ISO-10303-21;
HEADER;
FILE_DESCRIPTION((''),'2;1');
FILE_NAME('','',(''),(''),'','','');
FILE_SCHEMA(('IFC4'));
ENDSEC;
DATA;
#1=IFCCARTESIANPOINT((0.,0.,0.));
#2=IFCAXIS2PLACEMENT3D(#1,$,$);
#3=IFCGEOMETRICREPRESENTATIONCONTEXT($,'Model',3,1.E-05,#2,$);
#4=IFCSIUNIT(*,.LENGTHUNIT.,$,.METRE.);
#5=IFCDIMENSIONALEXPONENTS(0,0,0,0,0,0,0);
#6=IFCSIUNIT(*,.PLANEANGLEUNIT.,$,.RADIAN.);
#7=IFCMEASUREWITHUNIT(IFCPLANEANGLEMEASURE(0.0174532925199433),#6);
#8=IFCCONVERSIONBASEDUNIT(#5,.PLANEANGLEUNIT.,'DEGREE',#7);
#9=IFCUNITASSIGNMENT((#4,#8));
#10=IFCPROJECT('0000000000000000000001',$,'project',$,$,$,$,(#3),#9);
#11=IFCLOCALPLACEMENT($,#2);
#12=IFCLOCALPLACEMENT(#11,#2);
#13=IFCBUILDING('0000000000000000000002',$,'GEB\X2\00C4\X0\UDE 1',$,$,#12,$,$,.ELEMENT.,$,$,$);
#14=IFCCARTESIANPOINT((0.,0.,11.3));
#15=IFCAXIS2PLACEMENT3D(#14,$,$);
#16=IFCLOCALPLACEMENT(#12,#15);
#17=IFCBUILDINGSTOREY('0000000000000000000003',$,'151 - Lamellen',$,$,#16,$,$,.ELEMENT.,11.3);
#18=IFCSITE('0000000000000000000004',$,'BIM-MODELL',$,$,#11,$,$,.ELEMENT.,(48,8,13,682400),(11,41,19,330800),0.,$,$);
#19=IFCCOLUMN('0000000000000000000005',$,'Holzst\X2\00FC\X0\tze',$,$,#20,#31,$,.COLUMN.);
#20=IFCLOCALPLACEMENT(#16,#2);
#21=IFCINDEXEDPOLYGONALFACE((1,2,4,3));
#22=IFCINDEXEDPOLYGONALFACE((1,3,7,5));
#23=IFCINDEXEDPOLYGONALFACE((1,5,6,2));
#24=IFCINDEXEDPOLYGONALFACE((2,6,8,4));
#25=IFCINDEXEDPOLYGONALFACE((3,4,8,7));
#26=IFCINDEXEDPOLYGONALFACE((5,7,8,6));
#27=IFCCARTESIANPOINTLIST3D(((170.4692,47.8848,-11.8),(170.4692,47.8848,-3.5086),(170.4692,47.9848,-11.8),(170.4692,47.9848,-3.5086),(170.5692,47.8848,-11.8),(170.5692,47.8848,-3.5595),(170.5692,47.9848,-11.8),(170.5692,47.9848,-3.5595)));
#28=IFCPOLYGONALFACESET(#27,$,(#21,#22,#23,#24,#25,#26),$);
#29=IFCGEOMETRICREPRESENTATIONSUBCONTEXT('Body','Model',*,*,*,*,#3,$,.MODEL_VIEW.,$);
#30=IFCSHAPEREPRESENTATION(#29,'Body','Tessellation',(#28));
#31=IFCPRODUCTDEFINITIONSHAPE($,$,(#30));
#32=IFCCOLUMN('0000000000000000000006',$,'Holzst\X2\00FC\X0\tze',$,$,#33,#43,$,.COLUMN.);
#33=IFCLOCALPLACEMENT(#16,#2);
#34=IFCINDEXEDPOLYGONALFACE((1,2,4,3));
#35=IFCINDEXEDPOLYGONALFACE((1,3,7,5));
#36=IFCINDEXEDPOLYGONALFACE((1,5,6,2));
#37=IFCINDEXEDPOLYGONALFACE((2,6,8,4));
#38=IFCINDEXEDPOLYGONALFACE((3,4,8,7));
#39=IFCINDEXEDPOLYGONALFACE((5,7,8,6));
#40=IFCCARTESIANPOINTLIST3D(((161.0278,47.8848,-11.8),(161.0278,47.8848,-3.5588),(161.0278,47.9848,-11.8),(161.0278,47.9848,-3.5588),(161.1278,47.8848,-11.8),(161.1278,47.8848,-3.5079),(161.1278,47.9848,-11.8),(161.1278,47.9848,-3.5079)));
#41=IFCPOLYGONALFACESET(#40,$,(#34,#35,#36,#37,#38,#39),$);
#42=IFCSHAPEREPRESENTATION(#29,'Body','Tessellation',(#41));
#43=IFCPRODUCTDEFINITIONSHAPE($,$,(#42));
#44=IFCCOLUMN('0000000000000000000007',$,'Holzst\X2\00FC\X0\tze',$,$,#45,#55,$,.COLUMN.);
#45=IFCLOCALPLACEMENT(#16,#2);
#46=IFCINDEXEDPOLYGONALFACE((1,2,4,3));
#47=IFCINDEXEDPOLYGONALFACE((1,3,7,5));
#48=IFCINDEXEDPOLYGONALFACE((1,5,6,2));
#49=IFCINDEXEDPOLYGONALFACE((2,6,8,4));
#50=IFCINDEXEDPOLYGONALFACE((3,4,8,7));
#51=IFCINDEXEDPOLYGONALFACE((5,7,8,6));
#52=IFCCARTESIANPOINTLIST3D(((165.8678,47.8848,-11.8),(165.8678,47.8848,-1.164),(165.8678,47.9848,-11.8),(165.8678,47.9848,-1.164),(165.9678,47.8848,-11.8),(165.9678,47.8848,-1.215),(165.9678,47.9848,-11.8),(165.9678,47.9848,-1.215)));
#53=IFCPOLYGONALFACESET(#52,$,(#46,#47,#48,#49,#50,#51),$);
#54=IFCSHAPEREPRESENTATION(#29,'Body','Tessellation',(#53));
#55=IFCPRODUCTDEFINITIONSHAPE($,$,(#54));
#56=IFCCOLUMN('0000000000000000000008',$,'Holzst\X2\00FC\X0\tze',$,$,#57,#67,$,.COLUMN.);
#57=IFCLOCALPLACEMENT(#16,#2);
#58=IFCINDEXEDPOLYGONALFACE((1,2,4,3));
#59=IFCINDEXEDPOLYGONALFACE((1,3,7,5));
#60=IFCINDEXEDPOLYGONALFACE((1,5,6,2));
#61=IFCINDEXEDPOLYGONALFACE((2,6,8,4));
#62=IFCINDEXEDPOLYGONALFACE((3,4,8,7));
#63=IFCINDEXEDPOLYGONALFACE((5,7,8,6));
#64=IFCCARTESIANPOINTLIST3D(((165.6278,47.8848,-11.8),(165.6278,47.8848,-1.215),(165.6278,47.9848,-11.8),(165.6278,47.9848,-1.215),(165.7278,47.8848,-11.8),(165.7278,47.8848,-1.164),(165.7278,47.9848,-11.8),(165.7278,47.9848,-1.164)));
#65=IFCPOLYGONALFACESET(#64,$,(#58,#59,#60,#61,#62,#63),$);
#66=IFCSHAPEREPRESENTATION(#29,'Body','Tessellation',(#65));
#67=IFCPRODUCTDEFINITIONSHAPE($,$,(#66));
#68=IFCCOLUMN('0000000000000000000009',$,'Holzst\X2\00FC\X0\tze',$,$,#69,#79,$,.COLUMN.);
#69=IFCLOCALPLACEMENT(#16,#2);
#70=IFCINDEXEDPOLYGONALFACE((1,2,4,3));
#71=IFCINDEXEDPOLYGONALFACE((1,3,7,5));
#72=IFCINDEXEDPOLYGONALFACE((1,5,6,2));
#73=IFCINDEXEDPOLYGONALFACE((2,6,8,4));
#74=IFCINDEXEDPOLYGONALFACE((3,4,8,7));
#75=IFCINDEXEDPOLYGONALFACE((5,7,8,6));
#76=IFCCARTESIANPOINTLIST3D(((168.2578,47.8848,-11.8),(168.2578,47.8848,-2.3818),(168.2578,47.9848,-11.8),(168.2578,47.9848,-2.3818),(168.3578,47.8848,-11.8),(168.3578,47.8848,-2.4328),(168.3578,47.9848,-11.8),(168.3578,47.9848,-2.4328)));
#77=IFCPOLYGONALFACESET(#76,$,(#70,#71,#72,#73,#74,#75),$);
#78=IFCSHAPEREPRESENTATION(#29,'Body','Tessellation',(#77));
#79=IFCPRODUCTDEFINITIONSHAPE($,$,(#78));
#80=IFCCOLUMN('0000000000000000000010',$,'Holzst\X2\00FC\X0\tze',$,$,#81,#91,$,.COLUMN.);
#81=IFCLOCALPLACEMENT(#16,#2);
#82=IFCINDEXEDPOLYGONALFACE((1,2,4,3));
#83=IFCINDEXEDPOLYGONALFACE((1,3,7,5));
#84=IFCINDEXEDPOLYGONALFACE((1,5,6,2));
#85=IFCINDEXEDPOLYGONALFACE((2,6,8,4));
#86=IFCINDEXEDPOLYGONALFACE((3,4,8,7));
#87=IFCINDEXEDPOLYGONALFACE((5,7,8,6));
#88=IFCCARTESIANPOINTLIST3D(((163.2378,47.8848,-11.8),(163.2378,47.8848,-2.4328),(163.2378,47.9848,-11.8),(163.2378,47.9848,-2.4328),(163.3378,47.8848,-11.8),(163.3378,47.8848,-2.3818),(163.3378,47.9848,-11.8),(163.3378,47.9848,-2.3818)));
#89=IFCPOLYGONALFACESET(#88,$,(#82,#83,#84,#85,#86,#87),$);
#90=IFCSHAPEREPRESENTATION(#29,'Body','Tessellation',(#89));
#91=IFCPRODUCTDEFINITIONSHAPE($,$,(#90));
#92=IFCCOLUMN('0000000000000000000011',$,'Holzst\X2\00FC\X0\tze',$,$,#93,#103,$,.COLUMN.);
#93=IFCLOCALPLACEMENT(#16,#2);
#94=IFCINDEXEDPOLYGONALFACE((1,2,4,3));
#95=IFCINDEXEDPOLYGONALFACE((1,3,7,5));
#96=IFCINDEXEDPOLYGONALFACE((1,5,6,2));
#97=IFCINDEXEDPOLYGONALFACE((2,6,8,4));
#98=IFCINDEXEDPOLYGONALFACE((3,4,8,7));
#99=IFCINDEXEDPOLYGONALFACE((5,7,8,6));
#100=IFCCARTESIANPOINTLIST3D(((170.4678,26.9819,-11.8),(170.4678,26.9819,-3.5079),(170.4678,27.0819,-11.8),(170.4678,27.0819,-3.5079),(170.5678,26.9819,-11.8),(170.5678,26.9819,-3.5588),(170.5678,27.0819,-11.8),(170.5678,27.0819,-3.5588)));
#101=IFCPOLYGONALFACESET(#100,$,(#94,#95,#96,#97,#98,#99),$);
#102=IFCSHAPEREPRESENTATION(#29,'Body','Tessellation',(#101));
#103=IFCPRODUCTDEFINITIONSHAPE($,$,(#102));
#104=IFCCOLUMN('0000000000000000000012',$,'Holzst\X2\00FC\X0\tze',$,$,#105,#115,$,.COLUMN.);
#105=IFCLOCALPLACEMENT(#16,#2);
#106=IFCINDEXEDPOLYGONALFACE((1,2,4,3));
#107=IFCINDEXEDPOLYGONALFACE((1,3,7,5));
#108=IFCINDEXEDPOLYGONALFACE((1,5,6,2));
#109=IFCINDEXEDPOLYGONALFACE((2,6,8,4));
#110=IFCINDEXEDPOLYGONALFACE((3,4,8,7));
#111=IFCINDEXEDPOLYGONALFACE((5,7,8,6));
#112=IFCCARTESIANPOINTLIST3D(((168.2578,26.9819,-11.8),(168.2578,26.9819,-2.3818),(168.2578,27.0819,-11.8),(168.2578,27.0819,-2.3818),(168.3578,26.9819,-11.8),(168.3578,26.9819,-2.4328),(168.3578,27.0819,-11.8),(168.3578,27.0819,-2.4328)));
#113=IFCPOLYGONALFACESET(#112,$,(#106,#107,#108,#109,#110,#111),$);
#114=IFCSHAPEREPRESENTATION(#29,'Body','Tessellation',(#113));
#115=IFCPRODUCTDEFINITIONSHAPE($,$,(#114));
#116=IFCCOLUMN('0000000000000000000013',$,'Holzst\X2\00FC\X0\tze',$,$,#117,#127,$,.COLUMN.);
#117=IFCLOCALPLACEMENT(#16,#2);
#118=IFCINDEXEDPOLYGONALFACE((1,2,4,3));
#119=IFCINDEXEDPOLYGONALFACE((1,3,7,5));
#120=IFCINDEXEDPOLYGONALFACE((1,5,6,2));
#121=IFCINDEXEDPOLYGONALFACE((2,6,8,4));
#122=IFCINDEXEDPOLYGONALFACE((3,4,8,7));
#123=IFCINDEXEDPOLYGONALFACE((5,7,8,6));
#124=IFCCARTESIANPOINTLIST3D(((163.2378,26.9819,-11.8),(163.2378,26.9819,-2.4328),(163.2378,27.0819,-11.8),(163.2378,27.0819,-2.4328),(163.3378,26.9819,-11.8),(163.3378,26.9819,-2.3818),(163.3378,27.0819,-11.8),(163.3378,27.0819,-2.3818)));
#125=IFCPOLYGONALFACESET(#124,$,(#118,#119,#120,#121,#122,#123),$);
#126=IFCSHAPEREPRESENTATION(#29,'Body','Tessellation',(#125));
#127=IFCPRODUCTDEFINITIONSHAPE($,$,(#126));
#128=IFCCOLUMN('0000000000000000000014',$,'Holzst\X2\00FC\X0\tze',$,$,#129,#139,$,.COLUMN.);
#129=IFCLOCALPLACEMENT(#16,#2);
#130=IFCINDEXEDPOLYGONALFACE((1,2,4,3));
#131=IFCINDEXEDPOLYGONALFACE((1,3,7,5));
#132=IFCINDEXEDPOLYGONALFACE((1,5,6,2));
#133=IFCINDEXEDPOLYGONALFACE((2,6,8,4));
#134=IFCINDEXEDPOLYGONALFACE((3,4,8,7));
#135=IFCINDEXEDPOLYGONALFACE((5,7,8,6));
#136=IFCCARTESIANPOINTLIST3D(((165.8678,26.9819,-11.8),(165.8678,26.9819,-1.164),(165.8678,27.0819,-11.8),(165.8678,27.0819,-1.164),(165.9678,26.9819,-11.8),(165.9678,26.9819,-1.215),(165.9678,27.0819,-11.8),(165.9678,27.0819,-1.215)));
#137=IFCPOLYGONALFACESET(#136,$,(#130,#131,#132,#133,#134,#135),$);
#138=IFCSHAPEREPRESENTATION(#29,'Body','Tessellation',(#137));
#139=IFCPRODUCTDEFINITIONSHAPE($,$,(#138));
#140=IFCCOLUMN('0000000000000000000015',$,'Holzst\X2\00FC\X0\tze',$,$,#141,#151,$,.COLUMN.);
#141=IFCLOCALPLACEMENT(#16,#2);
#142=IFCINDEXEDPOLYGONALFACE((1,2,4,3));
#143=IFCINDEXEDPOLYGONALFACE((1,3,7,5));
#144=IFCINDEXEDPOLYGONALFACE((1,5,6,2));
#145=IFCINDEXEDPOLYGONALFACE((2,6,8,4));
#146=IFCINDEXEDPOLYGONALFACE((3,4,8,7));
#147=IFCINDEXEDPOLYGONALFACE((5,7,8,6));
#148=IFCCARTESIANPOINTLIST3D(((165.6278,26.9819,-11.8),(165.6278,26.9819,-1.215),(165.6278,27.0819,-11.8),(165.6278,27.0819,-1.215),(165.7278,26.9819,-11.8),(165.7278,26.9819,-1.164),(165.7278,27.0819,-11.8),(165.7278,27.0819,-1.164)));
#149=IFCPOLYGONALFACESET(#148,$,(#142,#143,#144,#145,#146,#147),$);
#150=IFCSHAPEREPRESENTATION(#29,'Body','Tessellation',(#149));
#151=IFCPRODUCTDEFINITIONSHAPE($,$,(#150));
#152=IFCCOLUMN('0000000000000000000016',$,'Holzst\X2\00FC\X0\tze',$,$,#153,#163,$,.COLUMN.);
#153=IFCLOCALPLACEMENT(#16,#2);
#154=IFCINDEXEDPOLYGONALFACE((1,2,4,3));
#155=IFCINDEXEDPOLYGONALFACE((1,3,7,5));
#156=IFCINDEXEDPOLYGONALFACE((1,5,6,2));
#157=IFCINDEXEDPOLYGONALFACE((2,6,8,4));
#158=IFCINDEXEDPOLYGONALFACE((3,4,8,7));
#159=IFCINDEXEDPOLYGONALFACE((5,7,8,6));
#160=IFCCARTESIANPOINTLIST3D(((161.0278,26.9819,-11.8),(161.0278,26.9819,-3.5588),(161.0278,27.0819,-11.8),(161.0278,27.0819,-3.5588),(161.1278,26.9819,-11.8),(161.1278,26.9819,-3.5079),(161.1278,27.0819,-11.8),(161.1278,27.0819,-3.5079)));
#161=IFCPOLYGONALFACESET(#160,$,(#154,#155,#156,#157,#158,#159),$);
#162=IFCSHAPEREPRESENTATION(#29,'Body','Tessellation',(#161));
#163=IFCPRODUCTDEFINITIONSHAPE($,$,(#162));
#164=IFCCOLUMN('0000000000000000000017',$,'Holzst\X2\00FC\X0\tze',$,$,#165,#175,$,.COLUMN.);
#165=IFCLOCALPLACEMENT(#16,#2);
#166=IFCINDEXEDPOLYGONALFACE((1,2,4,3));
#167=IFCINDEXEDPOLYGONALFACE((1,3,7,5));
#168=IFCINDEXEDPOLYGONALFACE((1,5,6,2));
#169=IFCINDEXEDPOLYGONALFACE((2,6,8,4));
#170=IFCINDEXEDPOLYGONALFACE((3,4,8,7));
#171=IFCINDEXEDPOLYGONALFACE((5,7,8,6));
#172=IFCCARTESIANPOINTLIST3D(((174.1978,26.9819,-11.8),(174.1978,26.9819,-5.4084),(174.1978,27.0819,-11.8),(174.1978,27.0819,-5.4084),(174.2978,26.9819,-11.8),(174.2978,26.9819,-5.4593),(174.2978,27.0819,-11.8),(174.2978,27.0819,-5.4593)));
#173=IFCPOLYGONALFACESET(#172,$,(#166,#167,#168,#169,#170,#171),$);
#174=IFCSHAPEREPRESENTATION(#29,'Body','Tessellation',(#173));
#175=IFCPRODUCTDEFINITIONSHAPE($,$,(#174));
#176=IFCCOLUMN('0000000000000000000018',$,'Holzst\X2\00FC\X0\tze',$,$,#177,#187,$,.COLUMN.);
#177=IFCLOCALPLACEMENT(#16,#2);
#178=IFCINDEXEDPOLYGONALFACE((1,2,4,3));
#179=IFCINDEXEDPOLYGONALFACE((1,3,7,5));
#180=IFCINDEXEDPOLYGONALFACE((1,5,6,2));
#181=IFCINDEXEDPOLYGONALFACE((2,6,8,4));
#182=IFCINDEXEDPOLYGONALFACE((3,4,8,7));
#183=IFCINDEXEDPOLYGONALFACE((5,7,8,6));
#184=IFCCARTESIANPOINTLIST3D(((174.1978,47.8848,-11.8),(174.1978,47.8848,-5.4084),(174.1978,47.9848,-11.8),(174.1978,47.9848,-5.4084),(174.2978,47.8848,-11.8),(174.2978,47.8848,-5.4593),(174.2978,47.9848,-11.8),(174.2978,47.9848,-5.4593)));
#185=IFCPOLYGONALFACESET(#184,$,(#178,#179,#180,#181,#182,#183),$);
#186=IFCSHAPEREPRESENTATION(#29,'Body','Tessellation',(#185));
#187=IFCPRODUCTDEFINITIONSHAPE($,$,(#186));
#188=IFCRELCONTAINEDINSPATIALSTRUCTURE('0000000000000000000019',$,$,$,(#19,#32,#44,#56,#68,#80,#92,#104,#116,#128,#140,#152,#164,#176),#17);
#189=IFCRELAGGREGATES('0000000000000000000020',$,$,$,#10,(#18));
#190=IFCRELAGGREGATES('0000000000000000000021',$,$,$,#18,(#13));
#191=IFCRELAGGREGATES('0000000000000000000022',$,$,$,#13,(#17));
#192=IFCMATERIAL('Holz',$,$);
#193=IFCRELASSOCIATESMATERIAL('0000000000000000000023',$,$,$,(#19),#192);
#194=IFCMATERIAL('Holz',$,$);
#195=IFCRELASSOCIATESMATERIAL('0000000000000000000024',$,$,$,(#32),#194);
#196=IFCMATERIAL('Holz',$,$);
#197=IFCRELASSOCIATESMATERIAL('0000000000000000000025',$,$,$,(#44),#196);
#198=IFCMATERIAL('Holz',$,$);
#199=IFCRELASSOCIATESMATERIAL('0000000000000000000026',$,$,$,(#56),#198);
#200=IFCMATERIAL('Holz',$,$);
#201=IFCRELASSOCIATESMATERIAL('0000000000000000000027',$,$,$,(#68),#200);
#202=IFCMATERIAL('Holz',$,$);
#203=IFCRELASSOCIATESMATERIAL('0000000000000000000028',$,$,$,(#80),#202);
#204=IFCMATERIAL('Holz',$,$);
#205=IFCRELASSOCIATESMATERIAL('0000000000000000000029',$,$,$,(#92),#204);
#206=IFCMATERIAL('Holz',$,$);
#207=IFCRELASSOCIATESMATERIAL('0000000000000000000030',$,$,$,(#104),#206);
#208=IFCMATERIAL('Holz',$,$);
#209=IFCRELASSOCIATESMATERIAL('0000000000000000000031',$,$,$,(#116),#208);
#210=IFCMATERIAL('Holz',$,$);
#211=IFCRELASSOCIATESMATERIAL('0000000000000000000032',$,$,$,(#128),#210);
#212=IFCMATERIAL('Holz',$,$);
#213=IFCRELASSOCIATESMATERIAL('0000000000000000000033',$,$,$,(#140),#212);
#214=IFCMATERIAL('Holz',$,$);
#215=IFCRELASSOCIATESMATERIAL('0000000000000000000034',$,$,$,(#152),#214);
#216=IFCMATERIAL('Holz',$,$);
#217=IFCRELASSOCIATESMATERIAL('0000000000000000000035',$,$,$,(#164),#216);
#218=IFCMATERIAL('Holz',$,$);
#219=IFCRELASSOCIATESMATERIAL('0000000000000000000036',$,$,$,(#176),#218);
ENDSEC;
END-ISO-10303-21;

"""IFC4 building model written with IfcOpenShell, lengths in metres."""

from ifc_helpers import new_model, entity, si_unit, converted_unit, frame, frame_2d, origin, origin_with_axes, place, context, subcontext, project, spatial, rectangle, extrude, clip, halfspace, material, element, save


model = new_model("IFC4")

# Units and contexts
model_context = context("Model", 3, precision=1e-05, world=origin())
body_context = subcontext(model_context, "Body", "Model", "MODEL_VIEW")
ifc_project = project(units=[si_unit("LENGTHUNIT", "METRE"), converted_unit("PLANEANGLEUNIT", "DEGREE", entity("IfcPlaneAngleMeasure", 0.0174532925199433), si_unit("PLANEANGLEUNIT", "RADIAN"), dimensions=[0, 0, 0, 0, 0, 0, 0])], contexts=[model_context])

# Site, building, storey
site_placement = place(None, origin())
site = spatial("IfcSite", under=ifc_project, at=site_placement, Name="BIM-MODELL", CompositionType="ELEMENT", RefLatitude=(48, 8, 13, 682400), RefLongitude=(11, 41, 19, 330800), RefElevation=0.0)
building_placement = place(site_placement, origin())
building = spatial("IfcBuilding", under=site, at=building_placement, Name="GEBÄUDE 1", CompositionType="ELEMENT")
storey_placement = place(building_placement, frame((0.0, 0.0, 11.3)))
storey = spatial("IfcBuildingStorey", under=building, at=storey_placement, Name="151 - Lamellen", CompositionType="ELEMENT", Elevation=11.3)

# Columns
ifc_material_1 = material(Name="Holz")
column_1_placement = place(storey_placement, frame((170.5692, 47.8848, -11.8)))
element("IfcColumn", 1, at=column_1_placement, inside=storey, material=ifc_material_1, Name="Holzstütze", PredefinedType="COLUMN", context=body_context, shape_type="Clipping", body=[
    clip(extrude(rectangle(XDim=0.1, YDim=0.1, at=frame_2d((-0.05, 0.05), x_axis=(0.0, 1.0))), origin_with_axes(), (0.0, 0.0, 1.0), 8.2914), halfspace(frame((-0.05, 0.05, 8.2659), z_axis=(-0.45399, 0.0, -0.891007), x_axis=(0.0, 1.0, 0.0)), True)),
])
ifc_material_2 = material(Name="Holz")
column_2_placement = place(storey_placement, frame((161.1278, 47.8848, -11.8)))
element("IfcColumn", 2, at=column_2_placement, inside=storey, material=ifc_material_2, Name="Holzstütze", PredefinedType="COLUMN", context=body_context, shape_type="Clipping", body=[
    clip(extrude(rectangle(XDim=0.1, YDim=0.1, at=frame_2d((-0.05, 0.05), x_axis=(0.0, 1.0))), origin_with_axes(), (0.0, 0.0, 1.0), 8.2921), halfspace(frame((-0.05, 0.05, 8.2667), z_axis=(0.45399, 0.0, -0.891007), x_axis=(0.0, 1.0, 0.0)), True)),
])
ifc_material_3 = material(Name="Holz")
column_3_placement = place(storey_placement, frame((165.9678, 47.8848, -11.8)))
element("IfcColumn", 3, at=column_3_placement, inside=storey, material=ifc_material_3, Name="Holzstütze", PredefinedType="COLUMN", context=body_context, shape_type="Clipping", body=[
    clip(extrude(rectangle(XDim=0.1, YDim=0.1, at=frame_2d((-0.05, 0.05), x_axis=(0.0, 1.0))), origin_with_axes(), (0.0, 0.0, 1.0), 10.636), halfspace(frame((-0.05, 0.05, 10.6105), z_axis=(-0.45399, 0.0, -0.891007), x_axis=(0.0, 1.0, 0.0)), True)),
])
ifc_material_4 = material(Name="Holz")
column_4_placement = place(storey_placement, frame((165.7278, 47.8848, -11.8)))
element("IfcColumn", 4, at=column_4_placement, inside=storey, material=ifc_material_4, Name="Holzstütze", PredefinedType="COLUMN", context=body_context, shape_type="Clipping", body=[
    clip(extrude(rectangle(XDim=0.1, YDim=0.1, at=frame_2d((-0.05, 0.05), x_axis=(0.0, 1.0))), origin_with_axes(), (0.0, 0.0, 1.0), 10.636), halfspace(frame((-0.05, 0.05, 10.6105), z_axis=(0.45399, 0.0, -0.891007), x_axis=(0.0, 1.0, 0.0)), True)),
])
ifc_material_5 = material(Name="Holz")
column_5_placement = place(storey_placement, frame((168.3578, 47.8848, -11.8)))
element("IfcColumn", 5, at=column_5_placement, inside=storey, material=ifc_material_5, Name="Holzstütze", PredefinedType="COLUMN", context=body_context, shape_type="Clipping", body=[
    clip(extrude(rectangle(XDim=0.1, YDim=0.1, at=frame_2d((-0.05, 0.05), x_axis=(0.0, 1.0))), origin_with_axes(), (0.0, 0.0, 1.0), 9.4182), halfspace(frame((-0.05, 0.05, 9.3927), z_axis=(-0.45399, 0.0, -0.891007), x_axis=(0.0, 1.0, 0.0)), True)),
])
ifc_material_6 = material(Name="Holz")
column_6_placement = place(storey_placement, frame((163.3378, 47.8848, -11.8)))
element("IfcColumn", 6, at=column_6_placement, inside=storey, material=ifc_material_6, Name="Holzstütze", PredefinedType="COLUMN", context=body_context, shape_type="Clipping", body=[
    clip(extrude(rectangle(XDim=0.1, YDim=0.1, at=frame_2d((-0.05, 0.05), x_axis=(0.0, 1.0))), origin_with_axes(), (0.0, 0.0, 1.0), 9.4182), halfspace(frame((-0.05, 0.05, 9.3927), z_axis=(0.45399, 0.0, -0.891007), x_axis=(0.0, 1.0, 0.0)), True)),
])
ifc_material_7 = material(Name="Holz")
column_7_placement = place(storey_placement, frame((170.5678, 26.9819, -11.8)))
element("IfcColumn", 7, at=column_7_placement, inside=storey, material=ifc_material_7, Name="Holzstütze", PredefinedType="COLUMN", context=body_context, shape_type="Clipping", body=[
    clip(extrude(rectangle(XDim=0.1, YDim=0.1, at=frame_2d((-0.05, 0.05), x_axis=(0.0, 1.0))), origin_with_axes(), (0.0, 0.0, 1.0), 8.2921), halfspace(frame((-0.05, 0.05, 8.2667), z_axis=(-0.45399, 0.0, -0.891007), x_axis=(0.0, -1.0, 0.0)), True)),
])
ifc_material_8 = material(Name="Holz")
column_8_placement = place(storey_placement, frame((168.3578, 26.9819, -11.8)))
element("IfcColumn", 8, at=column_8_placement, inside=storey, material=ifc_material_8, Name="Holzstütze", PredefinedType="COLUMN", context=body_context, shape_type="Clipping", body=[
    clip(extrude(rectangle(XDim=0.1, YDim=0.1, at=frame_2d((-0.05, 0.05), x_axis=(0.0, 1.0))), origin_with_axes(), (0.0, 0.0, 1.0), 9.4182), halfspace(frame((-0.05, 0.05, 9.3927), z_axis=(-0.45399, 0.0, -0.891007), x_axis=(0.0, -1.0, 0.0)), True)),
])
ifc_material_9 = material(Name="Holz")
column_9_placement = place(storey_placement, frame((163.3378, 26.9819, -11.8)))
element("IfcColumn", 9, at=column_9_placement, inside=storey, material=ifc_material_9, Name="Holzstütze", PredefinedType="COLUMN", context=body_context, shape_type="Clipping", body=[
    clip(extrude(rectangle(XDim=0.1, YDim=0.1, at=frame_2d((-0.05, 0.05), x_axis=(0.0, 1.0))), origin_with_axes(), (0.0, 0.0, 1.0), 9.4182), halfspace(frame((-0.05, 0.05, 9.3927), z_axis=(0.45399, 0.0, -0.891007), x_axis=(0.0, -1.0, 0.0)), True)),
])
ifc_material_10 = material(Name="Holz")
column_10_placement = place(storey_placement, frame((165.9678, 26.9819, -11.8)))
element("IfcColumn", 10, at=column_10_placement, inside=storey, material=ifc_material_10, Name="Holzstütze", PredefinedType="COLUMN", context=body_context, shape_type="Clipping", body=[
    clip(extrude(rectangle(XDim=0.1, YDim=0.1, at=frame_2d((-0.05, 0.05), x_axis=(0.0, 1.0))), origin_with_axes(), (0.0, 0.0, 1.0), 10.636), halfspace(frame((-0.05, 0.05, 10.6105), z_axis=(-0.45399, 0.0, -0.891007), x_axis=(0.0, -1.0, 0.0)), True)),
])
ifc_material_11 = material(Name="Holz")
column_11_placement = place(storey_placement, frame((165.7278, 26.9819, -11.8)))
element("IfcColumn", 11, at=column_11_placement, inside=storey, material=ifc_material_11, Name="Holzstütze", PredefinedType="COLUMN", context=body_context, shape_type="Clipping", body=[
    clip(extrude(rectangle(XDim=0.1, YDim=0.1, at=frame_2d((-0.05, 0.05), x_axis=(0.0, 1.0))), origin_with_axes(), (0.0, 0.0, 1.0), 10.636), halfspace(frame((-0.05, 0.05, 10.6105), z_axis=(0.45399, 0.0, -0.891007), x_axis=(0.0, -1.0, 0.0)), True)),
])
ifc_material_12 = material(Name="Holz")
column_12_placement = place(storey_placement, frame((161.1278, 26.9819, -11.8)))
element("IfcColumn", 12, at=column_12_placement, inside=storey, material=ifc_material_12, Name="Holzstütze", PredefinedType="COLUMN", context=body_context, shape_type="Clipping", body=[
    clip(extrude(rectangle(XDim=0.1, YDim=0.1, at=frame_2d((-0.05, 0.05), x_axis=(0.0, 1.0))), origin_with_axes(), (0.0, 0.0, 1.0), 8.2921), halfspace(frame((-0.05, 0.05, 8.2667), z_axis=(0.45399, 0.0, -0.891007), x_axis=(0.0, -1.0, 0.0)), True)),
])
ifc_material_13 = material(Name="Holz")
column_13_placement = place(storey_placement, frame((174.2978, 26.9819, -11.8)))
element("IfcColumn", 13, at=column_13_placement, inside=storey, material=ifc_material_13, Name="Holzstütze", PredefinedType="COLUMN", context=body_context, shape_type="Clipping", body=[
    clip(extrude(rectangle(XDim=0.1, YDim=0.1, at=frame_2d((-0.05, 0.05), x_axis=(0.0, 1.0))), origin_with_axes(), (0.0, 0.0, 1.0), 6.3916), halfspace(frame((-0.05, 0.05, 6.3661), z_axis=(-0.45399, 0.0, -0.891007), x_axis=(0.0, -1.0, 0.0)), True)),
])
ifc_material_14 = material(Name="Holz")
column_14_placement = place(storey_placement, frame((174.2978, 47.8848, -11.8)))
element("IfcColumn", 14, at=column_14_placement, inside=storey, material=ifc_material_14, Name="Holzstütze", PredefinedType="COLUMN", context=body_context, shape_type="Clipping", body=[
    clip(extrude(rectangle(XDim=0.1, YDim=0.1, at=frame_2d((-0.05, 0.05), x_axis=(0.0, 1.0))), origin_with_axes(), (0.0, 0.0, 1.0), 6.3916), halfspace(frame((-0.05, 0.05, 6.3661), z_axis=(-0.45399, 0.0, -0.891007), x_axis=(0.891007, 0.0, -0.45399)), True)),
])

save(model, "model.ifc")
